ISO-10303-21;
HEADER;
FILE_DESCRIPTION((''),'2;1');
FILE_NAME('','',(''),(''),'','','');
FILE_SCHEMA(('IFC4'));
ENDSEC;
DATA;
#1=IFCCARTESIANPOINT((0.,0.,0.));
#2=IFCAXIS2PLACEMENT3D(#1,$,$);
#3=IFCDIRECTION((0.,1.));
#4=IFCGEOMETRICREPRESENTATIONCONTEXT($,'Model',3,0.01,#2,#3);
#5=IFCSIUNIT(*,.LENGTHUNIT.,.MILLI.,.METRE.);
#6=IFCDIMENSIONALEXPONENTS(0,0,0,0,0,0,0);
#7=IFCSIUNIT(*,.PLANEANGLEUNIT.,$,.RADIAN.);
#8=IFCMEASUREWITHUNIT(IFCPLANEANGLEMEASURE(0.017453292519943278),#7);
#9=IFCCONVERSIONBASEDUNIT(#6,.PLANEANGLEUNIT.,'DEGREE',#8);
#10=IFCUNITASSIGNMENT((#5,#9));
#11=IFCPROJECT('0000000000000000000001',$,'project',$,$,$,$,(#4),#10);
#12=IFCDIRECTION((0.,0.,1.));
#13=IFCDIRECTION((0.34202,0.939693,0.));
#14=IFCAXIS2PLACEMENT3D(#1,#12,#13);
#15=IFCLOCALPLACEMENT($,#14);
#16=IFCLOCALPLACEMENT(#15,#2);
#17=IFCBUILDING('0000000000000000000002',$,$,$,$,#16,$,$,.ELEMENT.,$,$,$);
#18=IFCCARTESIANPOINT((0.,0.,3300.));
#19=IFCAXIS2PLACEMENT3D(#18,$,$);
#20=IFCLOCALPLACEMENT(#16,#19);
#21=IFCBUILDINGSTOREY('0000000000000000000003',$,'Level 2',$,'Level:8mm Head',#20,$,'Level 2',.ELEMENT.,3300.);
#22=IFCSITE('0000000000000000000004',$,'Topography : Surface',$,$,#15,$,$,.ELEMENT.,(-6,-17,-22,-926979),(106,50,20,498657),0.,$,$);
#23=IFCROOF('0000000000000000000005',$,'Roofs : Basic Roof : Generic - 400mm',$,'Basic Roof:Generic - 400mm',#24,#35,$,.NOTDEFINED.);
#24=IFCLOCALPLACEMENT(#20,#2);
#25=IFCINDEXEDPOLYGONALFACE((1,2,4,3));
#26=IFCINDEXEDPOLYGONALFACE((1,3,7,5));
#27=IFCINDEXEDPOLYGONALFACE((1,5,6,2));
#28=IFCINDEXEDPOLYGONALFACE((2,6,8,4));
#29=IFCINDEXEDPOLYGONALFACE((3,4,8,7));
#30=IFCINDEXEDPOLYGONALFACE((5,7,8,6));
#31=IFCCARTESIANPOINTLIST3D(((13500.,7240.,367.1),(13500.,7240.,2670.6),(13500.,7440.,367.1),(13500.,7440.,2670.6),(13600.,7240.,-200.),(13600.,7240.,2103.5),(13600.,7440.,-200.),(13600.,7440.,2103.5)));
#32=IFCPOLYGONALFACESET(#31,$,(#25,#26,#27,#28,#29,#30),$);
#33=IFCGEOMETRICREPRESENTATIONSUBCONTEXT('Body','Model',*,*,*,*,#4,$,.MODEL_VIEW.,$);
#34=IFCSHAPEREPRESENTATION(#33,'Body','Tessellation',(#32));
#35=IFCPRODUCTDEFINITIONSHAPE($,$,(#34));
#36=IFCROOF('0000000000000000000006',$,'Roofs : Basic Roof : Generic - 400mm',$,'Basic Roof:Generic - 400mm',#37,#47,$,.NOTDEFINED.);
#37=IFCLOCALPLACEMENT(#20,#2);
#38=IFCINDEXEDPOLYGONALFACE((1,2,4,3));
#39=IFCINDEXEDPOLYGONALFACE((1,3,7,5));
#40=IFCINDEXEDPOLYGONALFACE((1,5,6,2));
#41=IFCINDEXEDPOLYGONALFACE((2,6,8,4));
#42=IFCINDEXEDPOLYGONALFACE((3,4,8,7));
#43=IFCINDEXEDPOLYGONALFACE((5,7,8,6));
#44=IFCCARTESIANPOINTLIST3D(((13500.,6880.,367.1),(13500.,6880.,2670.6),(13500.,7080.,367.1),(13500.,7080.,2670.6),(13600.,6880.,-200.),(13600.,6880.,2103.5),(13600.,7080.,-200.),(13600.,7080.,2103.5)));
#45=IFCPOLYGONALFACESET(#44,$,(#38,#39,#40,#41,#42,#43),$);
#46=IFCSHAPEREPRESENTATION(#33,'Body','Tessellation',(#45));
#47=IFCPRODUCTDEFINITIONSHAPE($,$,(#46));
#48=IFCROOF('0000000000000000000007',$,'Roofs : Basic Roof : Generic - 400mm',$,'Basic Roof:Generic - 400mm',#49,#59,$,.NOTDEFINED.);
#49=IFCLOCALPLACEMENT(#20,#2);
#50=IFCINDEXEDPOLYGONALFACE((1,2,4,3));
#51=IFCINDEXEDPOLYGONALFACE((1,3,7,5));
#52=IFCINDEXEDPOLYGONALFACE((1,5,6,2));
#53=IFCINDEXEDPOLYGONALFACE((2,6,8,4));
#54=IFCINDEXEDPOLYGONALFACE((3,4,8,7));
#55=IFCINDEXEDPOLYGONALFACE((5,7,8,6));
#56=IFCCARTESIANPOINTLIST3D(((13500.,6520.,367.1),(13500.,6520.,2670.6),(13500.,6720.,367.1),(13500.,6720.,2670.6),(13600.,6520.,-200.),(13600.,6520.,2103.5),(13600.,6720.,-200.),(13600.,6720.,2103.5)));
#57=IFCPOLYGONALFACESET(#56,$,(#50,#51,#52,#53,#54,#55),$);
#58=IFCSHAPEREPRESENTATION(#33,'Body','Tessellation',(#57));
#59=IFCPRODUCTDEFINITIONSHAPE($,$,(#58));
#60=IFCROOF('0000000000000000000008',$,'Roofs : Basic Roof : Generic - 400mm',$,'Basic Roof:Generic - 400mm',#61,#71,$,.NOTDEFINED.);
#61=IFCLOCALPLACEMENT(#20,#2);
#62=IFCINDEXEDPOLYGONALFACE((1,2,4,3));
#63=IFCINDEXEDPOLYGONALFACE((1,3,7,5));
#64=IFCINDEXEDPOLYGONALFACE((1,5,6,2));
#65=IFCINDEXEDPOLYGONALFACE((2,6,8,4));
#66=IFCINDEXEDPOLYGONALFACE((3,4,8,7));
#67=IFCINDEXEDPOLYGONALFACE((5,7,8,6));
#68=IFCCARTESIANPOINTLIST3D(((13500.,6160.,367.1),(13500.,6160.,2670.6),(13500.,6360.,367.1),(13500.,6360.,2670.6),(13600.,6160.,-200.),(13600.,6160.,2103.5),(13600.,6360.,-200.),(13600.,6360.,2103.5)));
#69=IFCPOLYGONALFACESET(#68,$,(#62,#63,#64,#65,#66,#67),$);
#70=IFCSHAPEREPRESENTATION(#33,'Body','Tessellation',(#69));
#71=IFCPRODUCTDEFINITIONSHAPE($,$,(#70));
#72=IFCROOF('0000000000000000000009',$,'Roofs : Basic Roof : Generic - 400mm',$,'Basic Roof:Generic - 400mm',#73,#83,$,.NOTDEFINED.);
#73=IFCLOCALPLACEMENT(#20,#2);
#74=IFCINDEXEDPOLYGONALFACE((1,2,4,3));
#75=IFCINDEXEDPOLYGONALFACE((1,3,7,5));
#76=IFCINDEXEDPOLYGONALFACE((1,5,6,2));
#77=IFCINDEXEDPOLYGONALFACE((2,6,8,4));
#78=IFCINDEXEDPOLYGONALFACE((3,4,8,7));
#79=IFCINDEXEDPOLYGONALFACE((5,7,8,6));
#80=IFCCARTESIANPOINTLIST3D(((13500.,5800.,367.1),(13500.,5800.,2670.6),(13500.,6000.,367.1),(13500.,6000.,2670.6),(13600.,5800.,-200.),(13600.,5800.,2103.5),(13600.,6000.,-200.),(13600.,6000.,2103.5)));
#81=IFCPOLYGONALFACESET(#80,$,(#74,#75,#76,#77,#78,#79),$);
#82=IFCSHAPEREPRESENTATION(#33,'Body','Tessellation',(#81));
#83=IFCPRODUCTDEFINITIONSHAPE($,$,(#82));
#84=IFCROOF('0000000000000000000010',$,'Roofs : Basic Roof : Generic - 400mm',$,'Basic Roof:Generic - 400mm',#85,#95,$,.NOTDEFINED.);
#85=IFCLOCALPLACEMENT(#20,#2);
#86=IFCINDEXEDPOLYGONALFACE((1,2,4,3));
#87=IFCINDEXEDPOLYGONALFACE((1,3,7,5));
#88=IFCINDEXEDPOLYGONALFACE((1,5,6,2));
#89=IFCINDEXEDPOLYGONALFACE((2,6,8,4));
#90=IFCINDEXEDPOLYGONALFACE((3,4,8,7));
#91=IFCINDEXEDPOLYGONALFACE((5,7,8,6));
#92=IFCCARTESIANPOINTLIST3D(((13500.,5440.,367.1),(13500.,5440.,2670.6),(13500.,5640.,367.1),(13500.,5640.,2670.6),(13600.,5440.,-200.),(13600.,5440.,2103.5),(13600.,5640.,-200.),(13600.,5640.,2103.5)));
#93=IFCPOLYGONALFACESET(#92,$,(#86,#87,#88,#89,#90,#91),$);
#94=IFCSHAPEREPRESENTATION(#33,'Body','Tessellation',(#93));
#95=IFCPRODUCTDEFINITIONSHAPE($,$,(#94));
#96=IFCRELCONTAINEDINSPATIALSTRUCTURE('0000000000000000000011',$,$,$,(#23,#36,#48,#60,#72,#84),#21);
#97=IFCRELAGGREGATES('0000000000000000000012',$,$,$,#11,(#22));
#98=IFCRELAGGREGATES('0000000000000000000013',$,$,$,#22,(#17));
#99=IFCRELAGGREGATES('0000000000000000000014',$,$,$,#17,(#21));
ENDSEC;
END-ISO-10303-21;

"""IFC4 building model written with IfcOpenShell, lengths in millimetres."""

from ifc_helpers import new_model, entity, si_unit, converted_unit, direction, frame, origin, place, context, subcontext, project, spatial, indexed_curve, outline, extrude, element, save


model = new_model("IFC4")

# Units and contexts
model_context = context("Model", 3, precision=0.01, world=origin(), true_north=direction((0.0, 1.0)))
body_context = subcontext(model_context, "Body", "Model", "MODEL_VIEW")
ifc_project = project(units=[si_unit("LENGTHUNIT", "METRE", prefix="MILLI"), converted_unit("PLANEANGLEUNIT", "DEGREE", entity("IfcPlaneAngleMeasure", 0.017453292519943278), si_unit("PLANEANGLEUNIT", "RADIAN"), dimensions=[0, 0, 0, 0, 0, 0, 0])], contexts=[model_context])

# Site, building, storey
site_placement = place(None, frame((0.0, 0.0, 0.0), z_axis=(0.0, 0.0, 1.0), x_axis=(0.34202, 0.939693, 0.0)))
site = spatial("IfcSite", under=ifc_project, at=site_placement, Name="Topography : Surface", CompositionType="ELEMENT", RefLatitude=(-6, -17, -22, -926979), RefLongitude=(106, 50, 20, 498657), RefElevation=0.0)
building_placement = place(site_placement, origin())
building = spatial("IfcBuilding", under=site, at=building_placement, CompositionType="ELEMENT")
storey_placement = place(building_placement, frame((0.0, 0.0, 3300.0)))
storey = spatial("IfcBuildingStorey", under=building, at=storey_placement, Name="Level 2", ObjectType="Level:8mm Head", LongName="Level 2", CompositionType="ELEMENT", Elevation=3300.0)

# Roofs
roof_1_placement = place(storey_placement, frame((13500.0, 7240.0, -200.0)))
element("IfcRoof", 1, at=roof_1_placement, inside=storey, Name="Roofs : Basic Roof : Generic - 400mm", ObjectType="Basic Roof:Generic - 400mm", PredefinedType="NOTDEFINED", context=body_context, shape_type="SweptSolid", body=[
    extrude(outline(indexed_curve([(-287.9, 100.0), (-287.9, -100.0), (287.9, -100.0), (287.9, 100.0), (-287.9, 100.0)], self_intersect=False)), frame((50.0, 100.0, 283.6), z_axis=(0.984808, 0.0, 0.173648), x_axis=(0.173648, 0.0, -0.984808)), (-0.984808, 0.0, 0.173648), 2303.5),
])
roof_2_placement = place(storey_placement, frame((13500.0, 6880.0, -200.0)))
element("IfcRoof", 2, at=roof_2_placement, inside=storey, Name="Roofs : Basic Roof : Generic - 400mm", ObjectType="Basic Roof:Generic - 400mm", PredefinedType="NOTDEFINED", context=body_context, shape_type="SweptSolid", body=[
    extrude(outline(indexed_curve([(-287.9, 100.0), (-287.9, -100.0), (287.9, -100.0), (287.9, 100.0), (-287.9, 100.0)], self_intersect=False)), frame((50.0, 100.0, 283.6), z_axis=(0.984808, 0.0, 0.173648), x_axis=(0.173648, 0.0, -0.984808)), (-0.984808, 0.0, 0.173648), 2303.5),
])
roof_3_placement = place(storey_placement, frame((13500.0, 6520.0, -200.0)))
element("IfcRoof", 3, at=roof_3_placement, inside=storey, Name="Roofs : Basic Roof : Generic - 400mm", ObjectType="Basic Roof:Generic - 400mm", PredefinedType="NOTDEFINED", context=body_context, shape_type="SweptSolid", body=[
    extrude(outline(indexed_curve([(-287.9, 100.0), (-287.9, -100.0), (287.9, -100.0), (287.9, 100.0), (-287.9, 100.0)], self_intersect=False)), frame((50.0, 100.0, 283.6), z_axis=(0.984808, 0.0, 0.173648), x_axis=(0.173648, 0.0, -0.984808)), (-0.984808, 0.0, 0.173648), 2303.5),
])
roof_4_placement = place(storey_placement, frame((13500.0, 6160.0, -200.0)))
element("IfcRoof", 4, at=roof_4_placement, inside=storey, Name="Roofs : Basic Roof : Generic - 400mm", ObjectType="Basic Roof:Generic - 400mm", PredefinedType="NOTDEFINED", context=body_context, shape_type="SweptSolid", body=[
    extrude(outline(indexed_curve([(-287.9, 100.0), (-287.9, -100.0), (287.9, -100.0), (287.9, 100.0), (-287.9, 100.0)], self_intersect=False)), frame((50.0, 100.0, 283.6), z_axis=(0.984808, 0.0, 0.173648), x_axis=(0.173648, 0.0, -0.984808)), (-0.984808, 0.0, 0.173648), 2303.5),
])
roof_5_placement = place(storey_placement, frame((13500.0, 5800.0, -200.0)))
element("IfcRoof", 5, at=roof_5_placement, inside=storey, Name="Roofs : Basic Roof : Generic - 400mm", ObjectType="Basic Roof:Generic - 400mm", PredefinedType="NOTDEFINED", context=body_context, shape_type="SweptSolid", body=[
    extrude(outline(indexed_curve([(-287.9, 100.0), (-287.9, -100.0), (287.9, -100.0), (287.9, 100.0), (-287.9, 100.0)], self_intersect=False)), frame((50.0, 100.0, 283.6), z_axis=(0.984808, 0.0, 0.173648), x_axis=(0.173648, 0.0, -0.984808)), (-0.984808, 0.0, 0.173648), 2303.5),
])
roof_6_placement = place(storey_placement, frame((13500.0, 5440.0, -200.0)))
element("IfcRoof", 6, at=roof_6_placement, inside=storey, Name="Roofs : Basic Roof : Generic - 400mm", ObjectType="Basic Roof:Generic - 400mm", PredefinedType="NOTDEFINED", context=body_context, shape_type="SweptSolid", body=[
    extrude(outline(indexed_curve([(-287.9, 100.0), (-287.9, -100.0), (287.9, -100.0), (287.9, 100.0), (-287.9, 100.0)], self_intersect=False)), frame((50.0, 100.0, 283.6), z_axis=(0.984808, 0.0, 0.173648), x_axis=(0.173648, 0.0, -0.984808)), (-0.984808, 0.0, 0.173648), 2303.5),
])

save(model, "model.ifc")
